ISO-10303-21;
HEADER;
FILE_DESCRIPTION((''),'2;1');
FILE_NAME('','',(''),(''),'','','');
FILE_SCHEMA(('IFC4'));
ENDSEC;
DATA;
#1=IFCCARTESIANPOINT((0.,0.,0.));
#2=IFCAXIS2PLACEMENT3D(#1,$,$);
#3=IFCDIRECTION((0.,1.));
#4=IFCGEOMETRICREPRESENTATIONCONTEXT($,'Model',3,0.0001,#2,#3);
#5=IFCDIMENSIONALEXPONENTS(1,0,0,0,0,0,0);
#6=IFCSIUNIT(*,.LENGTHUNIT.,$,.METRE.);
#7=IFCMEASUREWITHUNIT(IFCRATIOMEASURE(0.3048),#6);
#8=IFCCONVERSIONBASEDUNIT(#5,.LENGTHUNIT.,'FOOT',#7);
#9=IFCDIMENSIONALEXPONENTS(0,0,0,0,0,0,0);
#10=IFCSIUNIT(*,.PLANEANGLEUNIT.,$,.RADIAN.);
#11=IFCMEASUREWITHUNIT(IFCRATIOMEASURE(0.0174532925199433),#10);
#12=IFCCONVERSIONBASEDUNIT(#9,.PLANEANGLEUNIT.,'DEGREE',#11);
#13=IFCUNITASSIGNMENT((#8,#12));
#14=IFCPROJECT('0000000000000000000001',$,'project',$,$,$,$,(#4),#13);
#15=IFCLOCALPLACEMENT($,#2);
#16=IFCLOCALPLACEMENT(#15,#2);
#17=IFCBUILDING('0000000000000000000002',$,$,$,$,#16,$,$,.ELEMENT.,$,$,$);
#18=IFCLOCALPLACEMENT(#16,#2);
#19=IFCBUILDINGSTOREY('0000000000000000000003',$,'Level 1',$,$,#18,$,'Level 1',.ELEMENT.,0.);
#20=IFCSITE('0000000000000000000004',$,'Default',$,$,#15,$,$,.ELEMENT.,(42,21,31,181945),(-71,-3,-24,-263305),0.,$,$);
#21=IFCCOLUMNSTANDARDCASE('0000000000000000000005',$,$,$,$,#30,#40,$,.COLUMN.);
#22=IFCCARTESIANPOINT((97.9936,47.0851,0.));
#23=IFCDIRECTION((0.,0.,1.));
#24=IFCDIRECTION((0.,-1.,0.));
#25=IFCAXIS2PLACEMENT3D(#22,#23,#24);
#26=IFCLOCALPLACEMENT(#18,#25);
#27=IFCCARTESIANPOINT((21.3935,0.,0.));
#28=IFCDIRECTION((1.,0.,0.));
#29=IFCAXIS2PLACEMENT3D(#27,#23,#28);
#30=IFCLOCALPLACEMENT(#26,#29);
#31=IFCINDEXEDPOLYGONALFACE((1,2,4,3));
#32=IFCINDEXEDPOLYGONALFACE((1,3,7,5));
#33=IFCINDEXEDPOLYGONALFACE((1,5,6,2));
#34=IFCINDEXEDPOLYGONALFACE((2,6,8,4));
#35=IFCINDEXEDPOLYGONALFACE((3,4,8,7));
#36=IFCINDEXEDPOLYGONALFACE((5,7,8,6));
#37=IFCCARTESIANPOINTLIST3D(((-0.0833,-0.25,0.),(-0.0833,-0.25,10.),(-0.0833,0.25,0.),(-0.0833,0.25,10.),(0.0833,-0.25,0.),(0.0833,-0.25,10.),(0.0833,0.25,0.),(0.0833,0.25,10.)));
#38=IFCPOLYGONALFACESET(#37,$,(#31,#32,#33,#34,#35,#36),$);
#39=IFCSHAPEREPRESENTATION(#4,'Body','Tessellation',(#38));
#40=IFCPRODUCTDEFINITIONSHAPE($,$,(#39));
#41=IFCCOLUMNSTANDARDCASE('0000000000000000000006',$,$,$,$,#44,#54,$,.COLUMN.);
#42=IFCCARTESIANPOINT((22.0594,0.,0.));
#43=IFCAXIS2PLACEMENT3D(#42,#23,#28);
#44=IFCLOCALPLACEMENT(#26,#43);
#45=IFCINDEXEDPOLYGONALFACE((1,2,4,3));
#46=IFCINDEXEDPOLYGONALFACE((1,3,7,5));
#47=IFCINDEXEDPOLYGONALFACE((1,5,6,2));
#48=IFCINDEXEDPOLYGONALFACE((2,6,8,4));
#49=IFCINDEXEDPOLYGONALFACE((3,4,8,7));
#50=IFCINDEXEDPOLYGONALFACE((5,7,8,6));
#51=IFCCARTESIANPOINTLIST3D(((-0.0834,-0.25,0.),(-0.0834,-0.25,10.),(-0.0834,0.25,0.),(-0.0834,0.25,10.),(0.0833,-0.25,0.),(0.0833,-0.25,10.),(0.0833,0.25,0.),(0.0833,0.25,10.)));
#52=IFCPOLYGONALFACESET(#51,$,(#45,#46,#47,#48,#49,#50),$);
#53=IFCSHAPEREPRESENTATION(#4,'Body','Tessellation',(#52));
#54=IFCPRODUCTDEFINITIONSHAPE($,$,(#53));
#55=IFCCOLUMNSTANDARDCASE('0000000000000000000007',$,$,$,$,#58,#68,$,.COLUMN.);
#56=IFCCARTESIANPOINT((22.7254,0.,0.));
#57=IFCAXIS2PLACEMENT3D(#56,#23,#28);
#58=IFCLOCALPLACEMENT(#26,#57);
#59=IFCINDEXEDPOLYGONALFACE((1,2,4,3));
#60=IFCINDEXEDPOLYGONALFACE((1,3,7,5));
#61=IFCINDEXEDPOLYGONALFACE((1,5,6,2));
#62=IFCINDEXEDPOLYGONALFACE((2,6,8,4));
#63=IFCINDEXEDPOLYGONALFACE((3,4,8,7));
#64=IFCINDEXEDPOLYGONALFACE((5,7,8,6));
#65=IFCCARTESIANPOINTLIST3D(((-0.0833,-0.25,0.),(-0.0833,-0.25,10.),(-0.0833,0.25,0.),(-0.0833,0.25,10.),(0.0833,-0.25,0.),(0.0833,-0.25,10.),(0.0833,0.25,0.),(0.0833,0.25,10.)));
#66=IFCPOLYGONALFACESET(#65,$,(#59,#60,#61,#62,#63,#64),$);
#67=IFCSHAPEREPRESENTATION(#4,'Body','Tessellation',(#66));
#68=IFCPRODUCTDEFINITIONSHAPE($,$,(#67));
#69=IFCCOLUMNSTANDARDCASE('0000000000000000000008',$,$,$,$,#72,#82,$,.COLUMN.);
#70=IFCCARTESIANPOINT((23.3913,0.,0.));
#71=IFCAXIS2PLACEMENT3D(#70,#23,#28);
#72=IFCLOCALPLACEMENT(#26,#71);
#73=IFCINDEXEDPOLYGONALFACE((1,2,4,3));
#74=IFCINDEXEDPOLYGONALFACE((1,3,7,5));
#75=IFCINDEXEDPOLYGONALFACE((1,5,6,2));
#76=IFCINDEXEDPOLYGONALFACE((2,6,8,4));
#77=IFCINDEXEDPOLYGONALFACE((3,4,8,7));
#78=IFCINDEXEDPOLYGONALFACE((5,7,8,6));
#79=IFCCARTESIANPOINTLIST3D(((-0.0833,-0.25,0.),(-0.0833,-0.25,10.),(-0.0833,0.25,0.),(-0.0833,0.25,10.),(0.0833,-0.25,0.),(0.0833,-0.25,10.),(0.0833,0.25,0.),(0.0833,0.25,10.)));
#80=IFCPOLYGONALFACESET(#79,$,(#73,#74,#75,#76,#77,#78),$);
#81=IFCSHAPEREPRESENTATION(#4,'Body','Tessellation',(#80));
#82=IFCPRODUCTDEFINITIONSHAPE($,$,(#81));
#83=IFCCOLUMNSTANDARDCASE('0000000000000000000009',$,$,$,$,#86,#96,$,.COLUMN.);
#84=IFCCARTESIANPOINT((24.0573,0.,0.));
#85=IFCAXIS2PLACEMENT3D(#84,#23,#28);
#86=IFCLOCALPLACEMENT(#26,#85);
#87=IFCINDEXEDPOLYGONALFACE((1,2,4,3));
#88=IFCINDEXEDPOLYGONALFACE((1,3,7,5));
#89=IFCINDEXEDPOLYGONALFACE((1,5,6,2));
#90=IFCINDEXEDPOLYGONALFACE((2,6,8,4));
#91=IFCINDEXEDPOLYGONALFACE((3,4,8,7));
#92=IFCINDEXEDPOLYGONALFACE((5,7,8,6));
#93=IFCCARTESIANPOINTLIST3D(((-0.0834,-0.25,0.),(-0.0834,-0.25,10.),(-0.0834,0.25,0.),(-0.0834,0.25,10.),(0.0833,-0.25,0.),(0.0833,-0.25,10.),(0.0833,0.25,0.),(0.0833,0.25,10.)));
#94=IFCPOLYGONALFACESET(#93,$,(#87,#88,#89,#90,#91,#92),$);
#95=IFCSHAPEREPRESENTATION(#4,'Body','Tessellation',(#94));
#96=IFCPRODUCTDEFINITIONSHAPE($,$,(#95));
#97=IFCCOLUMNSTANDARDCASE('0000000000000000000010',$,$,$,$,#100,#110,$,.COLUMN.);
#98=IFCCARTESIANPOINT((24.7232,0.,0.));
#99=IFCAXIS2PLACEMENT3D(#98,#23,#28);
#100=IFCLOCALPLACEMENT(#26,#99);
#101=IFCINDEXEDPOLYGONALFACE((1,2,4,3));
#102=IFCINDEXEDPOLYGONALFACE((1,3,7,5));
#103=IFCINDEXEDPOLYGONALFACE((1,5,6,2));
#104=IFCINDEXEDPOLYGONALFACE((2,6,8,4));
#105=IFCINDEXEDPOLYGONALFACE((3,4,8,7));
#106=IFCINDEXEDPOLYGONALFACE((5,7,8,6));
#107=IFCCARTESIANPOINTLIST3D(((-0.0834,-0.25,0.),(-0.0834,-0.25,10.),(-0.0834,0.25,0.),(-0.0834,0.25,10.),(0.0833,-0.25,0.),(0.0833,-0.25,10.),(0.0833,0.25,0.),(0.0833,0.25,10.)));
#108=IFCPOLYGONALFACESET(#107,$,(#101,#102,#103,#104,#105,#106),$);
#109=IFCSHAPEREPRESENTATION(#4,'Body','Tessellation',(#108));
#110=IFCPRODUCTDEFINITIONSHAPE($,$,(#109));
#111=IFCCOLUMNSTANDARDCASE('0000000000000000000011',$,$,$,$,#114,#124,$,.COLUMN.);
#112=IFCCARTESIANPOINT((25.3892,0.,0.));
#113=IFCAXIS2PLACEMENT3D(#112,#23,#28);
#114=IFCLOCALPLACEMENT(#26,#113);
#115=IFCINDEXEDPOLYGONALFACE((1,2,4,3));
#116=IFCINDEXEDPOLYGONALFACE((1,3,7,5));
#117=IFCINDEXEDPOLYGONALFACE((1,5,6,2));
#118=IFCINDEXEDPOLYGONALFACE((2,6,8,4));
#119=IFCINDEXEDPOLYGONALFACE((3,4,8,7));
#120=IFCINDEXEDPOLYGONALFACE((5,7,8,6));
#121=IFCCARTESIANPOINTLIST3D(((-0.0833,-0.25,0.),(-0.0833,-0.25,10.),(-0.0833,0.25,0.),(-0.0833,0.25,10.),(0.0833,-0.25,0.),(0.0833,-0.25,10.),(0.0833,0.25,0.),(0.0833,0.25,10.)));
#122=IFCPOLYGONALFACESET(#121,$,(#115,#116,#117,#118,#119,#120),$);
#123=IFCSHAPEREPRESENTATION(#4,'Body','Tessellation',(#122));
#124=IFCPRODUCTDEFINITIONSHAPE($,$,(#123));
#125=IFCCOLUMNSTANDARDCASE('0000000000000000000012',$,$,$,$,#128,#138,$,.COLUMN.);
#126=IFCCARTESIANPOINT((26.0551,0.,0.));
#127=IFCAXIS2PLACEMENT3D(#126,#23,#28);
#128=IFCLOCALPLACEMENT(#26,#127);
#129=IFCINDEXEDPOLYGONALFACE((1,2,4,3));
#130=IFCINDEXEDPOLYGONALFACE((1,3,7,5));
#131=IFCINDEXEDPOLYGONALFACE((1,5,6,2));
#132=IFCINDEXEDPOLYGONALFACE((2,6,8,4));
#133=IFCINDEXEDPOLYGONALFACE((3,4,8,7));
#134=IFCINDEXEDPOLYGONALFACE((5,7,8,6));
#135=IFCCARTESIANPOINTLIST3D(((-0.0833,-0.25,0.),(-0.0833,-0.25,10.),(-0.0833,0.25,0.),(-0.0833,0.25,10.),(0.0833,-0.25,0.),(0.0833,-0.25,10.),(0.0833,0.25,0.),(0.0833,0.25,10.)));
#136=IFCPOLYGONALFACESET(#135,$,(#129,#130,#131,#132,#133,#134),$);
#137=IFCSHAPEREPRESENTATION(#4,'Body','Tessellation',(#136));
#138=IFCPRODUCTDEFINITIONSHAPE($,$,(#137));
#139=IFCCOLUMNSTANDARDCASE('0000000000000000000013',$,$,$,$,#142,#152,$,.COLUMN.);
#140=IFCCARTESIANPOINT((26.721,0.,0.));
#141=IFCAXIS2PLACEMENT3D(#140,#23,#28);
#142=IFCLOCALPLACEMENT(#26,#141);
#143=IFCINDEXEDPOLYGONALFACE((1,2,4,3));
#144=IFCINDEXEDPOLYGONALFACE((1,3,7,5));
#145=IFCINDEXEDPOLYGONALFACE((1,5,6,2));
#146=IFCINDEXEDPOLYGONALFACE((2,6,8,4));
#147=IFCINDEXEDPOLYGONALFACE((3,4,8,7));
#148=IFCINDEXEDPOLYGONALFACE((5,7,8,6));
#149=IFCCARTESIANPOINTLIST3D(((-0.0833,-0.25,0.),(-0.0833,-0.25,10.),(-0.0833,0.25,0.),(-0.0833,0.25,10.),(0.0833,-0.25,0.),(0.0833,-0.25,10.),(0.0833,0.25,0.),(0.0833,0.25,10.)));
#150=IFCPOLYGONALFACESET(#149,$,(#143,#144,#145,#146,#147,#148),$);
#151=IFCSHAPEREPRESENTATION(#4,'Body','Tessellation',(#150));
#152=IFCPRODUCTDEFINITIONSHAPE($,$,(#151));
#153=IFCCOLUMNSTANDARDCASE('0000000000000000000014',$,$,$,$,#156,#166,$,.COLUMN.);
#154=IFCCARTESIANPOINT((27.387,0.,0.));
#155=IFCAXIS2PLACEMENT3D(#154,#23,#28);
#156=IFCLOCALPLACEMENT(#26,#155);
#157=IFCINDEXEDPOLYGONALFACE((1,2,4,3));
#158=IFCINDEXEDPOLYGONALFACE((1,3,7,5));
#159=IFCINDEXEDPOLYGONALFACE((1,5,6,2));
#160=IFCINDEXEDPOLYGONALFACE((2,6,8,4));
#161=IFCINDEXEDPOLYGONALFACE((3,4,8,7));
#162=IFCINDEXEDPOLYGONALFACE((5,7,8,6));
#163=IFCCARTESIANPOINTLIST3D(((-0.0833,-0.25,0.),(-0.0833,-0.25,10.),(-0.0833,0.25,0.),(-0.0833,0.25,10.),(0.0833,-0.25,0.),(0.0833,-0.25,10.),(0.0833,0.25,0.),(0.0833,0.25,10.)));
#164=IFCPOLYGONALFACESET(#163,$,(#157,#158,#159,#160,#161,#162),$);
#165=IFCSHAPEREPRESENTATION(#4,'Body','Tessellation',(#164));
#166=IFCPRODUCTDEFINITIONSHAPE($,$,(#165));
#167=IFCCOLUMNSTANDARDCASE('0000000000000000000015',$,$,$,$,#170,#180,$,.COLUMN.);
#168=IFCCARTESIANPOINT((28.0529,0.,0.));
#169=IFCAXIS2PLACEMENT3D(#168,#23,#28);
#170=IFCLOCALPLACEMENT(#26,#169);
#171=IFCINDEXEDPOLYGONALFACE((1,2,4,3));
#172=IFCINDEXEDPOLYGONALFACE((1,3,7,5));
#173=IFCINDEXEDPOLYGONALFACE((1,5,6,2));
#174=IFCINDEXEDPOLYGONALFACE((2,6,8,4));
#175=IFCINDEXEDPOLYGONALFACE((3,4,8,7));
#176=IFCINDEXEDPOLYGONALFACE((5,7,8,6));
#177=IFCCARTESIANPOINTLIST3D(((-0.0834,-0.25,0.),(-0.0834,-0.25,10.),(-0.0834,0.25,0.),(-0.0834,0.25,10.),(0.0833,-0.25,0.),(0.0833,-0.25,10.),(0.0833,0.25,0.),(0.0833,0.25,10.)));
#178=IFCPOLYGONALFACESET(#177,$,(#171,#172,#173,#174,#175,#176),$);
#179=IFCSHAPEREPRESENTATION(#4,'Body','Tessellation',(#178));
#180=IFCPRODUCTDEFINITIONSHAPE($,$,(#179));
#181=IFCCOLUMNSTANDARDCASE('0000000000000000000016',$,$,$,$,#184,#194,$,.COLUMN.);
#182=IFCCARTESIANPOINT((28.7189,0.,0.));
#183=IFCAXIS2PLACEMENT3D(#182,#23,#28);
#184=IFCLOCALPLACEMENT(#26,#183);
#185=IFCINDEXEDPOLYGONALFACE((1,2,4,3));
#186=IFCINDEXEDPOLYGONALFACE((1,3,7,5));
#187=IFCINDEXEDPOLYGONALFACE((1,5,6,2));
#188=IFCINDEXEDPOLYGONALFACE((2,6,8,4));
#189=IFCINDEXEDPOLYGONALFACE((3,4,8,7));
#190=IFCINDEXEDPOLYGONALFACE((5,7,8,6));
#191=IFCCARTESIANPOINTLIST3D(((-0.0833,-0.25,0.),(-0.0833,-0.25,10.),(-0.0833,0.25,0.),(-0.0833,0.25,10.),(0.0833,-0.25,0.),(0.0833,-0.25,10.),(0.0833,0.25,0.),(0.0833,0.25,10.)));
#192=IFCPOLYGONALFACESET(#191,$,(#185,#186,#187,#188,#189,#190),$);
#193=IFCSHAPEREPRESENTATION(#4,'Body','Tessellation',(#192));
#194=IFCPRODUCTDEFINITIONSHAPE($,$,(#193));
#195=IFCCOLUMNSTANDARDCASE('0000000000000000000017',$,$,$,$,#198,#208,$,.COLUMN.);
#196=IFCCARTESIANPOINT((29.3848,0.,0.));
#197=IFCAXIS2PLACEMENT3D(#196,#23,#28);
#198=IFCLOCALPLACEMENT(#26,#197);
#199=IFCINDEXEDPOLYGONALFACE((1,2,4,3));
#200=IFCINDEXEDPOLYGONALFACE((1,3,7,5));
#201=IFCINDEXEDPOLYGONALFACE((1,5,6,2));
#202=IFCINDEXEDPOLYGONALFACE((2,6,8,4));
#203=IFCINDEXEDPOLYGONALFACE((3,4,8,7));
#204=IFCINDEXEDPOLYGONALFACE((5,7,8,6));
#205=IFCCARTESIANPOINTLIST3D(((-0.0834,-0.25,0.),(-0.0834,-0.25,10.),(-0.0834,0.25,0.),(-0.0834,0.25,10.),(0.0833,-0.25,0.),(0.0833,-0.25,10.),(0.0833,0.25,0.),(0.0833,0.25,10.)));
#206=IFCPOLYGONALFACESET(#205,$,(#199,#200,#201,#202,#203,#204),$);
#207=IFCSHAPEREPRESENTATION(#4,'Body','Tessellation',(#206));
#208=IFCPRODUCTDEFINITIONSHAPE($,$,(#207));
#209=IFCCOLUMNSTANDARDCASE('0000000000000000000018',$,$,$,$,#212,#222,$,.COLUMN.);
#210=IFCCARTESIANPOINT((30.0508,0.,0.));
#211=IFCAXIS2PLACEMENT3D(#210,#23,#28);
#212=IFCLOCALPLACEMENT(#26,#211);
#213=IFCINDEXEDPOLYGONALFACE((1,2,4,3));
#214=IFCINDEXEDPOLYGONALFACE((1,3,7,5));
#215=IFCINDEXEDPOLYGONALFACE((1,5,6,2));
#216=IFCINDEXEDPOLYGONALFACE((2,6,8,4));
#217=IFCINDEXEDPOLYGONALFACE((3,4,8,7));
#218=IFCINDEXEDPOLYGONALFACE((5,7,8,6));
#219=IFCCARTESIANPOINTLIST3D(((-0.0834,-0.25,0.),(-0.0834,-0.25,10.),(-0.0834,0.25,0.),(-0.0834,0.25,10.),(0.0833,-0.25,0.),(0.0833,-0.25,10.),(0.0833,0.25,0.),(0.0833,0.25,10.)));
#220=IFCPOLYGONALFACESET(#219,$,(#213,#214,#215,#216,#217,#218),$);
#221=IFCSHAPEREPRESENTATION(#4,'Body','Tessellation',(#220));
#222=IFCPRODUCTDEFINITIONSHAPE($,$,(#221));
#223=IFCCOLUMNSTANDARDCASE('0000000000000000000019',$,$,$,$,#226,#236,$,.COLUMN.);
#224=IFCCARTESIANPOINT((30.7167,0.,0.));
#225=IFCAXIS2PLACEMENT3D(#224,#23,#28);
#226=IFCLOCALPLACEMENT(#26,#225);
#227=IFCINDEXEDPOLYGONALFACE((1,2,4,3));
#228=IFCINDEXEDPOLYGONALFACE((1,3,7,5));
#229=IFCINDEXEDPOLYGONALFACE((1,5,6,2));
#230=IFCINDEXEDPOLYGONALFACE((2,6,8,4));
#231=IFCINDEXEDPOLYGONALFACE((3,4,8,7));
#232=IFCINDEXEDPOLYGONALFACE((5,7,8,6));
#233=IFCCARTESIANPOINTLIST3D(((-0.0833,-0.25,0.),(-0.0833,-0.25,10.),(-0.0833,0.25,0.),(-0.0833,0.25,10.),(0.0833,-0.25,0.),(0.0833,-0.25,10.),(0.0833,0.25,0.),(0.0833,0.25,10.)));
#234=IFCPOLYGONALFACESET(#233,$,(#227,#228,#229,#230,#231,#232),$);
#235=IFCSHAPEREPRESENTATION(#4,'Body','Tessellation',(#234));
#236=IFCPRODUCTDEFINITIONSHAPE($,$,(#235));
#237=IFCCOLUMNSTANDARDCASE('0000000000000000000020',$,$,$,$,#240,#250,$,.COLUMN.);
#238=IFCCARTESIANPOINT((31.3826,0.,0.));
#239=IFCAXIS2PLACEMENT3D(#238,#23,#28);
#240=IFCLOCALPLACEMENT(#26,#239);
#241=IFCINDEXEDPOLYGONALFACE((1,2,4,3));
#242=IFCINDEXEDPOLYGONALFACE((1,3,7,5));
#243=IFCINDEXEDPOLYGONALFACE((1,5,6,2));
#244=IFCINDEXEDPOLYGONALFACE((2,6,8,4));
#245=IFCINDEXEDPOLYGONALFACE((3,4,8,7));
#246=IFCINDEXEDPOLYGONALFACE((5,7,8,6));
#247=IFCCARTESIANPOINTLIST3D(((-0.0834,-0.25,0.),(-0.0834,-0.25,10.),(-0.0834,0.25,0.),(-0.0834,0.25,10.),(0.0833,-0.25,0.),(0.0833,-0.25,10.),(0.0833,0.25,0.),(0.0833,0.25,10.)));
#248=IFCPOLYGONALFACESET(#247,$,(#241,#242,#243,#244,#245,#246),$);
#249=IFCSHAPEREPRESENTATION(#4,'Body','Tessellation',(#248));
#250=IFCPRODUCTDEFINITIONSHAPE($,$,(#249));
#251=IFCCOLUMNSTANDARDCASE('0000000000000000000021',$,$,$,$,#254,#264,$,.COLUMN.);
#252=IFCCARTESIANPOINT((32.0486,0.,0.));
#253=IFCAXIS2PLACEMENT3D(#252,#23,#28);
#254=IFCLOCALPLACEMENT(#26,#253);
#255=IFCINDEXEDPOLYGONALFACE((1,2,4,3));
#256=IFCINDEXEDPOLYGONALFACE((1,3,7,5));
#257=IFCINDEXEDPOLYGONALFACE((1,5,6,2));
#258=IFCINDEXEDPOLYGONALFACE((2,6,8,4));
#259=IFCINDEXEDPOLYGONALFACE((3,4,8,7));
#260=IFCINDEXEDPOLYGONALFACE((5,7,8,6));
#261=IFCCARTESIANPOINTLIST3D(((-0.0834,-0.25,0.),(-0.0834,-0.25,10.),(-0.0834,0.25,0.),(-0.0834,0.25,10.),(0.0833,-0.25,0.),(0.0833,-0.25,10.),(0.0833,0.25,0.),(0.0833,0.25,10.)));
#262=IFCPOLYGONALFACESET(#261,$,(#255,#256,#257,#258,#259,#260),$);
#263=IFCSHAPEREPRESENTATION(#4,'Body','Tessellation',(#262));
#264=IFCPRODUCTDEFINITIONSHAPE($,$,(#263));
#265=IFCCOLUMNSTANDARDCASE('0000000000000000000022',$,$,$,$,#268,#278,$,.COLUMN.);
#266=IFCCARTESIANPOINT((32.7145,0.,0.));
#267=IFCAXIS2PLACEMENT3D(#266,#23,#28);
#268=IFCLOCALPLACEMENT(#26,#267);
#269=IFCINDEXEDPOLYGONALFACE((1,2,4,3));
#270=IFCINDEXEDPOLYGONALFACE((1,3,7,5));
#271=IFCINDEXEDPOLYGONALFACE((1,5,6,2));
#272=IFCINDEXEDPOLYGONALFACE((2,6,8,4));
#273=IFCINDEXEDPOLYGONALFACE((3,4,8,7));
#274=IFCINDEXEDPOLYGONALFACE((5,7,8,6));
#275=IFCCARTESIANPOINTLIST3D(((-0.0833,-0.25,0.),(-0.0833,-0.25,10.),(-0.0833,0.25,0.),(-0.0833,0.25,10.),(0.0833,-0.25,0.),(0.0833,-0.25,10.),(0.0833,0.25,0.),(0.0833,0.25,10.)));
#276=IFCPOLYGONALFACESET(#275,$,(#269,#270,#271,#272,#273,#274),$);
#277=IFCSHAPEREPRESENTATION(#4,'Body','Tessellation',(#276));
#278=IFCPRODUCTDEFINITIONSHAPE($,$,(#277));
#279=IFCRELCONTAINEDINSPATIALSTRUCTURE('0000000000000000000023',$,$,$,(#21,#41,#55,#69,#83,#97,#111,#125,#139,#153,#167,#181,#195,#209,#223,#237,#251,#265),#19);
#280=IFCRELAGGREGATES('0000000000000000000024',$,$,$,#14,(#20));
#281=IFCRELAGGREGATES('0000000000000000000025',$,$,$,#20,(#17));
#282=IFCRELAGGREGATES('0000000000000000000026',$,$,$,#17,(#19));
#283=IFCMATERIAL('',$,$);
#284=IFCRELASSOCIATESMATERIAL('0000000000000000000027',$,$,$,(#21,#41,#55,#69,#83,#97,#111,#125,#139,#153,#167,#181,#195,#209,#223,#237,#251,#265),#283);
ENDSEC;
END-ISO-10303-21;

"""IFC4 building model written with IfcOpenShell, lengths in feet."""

from ifc_helpers import new_model, entity, si_unit, converted_unit, direction, frame, origin, place, context, project, spatial, rectangle, extrude, material, element, save


model = new_model("IFC4")

# Units and contexts
model_context = context("Model", 3, precision=0.0001, world=origin(), true_north=direction((0.0, 1.0)))
ifc_project = project(units=[converted_unit("LENGTHUNIT", "FOOT", entity("IfcRatioMeasure", 0.3048), si_unit("LENGTHUNIT", "METRE"), dimensions=[1, 0, 0, 0, 0, 0, 0]), converted_unit("PLANEANGLEUNIT", "DEGREE", entity("IfcRatioMeasure", 0.0174532925199433), si_unit("PLANEANGLEUNIT", "RADIAN"), dimensions=[0, 0, 0, 0, 0, 0, 0])], contexts=[model_context])

# Site, building, storey
site_placement = place(None, origin())
site = spatial("IfcSite", under=ifc_project, at=site_placement, Name="Default", CompositionType="ELEMENT", RefLatitude=(42, 21, 31, 181945), RefLongitude=(-71, -3, -24, -263305), RefElevation=0.0)
building_placement = place(site_placement, origin())
building = spatial("IfcBuilding", under=site, at=building_placement, CompositionType="ELEMENT")
storey_placement = place(building_placement, origin())
storey = spatial("IfcBuildingStorey", under=building, at=storey_placement, Name="Level 1", LongName="Level 1", CompositionType="ELEMENT", Elevation=0.0)

# Columns
ifc_material = material(Name="")
placement = place(storey_placement, frame((97.9936, 47.0851, 0.0), z_axis=(0.0, 0.0, 1.0), x_axis=(0.0, -1.0, 0.0)))
for number, where, z_axis, x_axis in (
    (1, (21.3935, 0.0, 0.0), (0.0, 0.0, 1.0), (1.0, 0.0, 0.0)),
    (2, (22.0594, 0.0, 0.0), (0.0, 0.0, 1.0), (1.0, 0.0, 0.0)),
    (3, (22.7254, 0.0, 0.0), (0.0, 0.0, 1.0), (1.0, 0.0, 0.0)),
    (4, (23.3913, 0.0, 0.0), (0.0, 0.0, 1.0), (1.0, 0.0, 0.0)),
    (5, (24.0573, 0.0, 0.0), (0.0, 0.0, 1.0), (1.0, 0.0, 0.0)),
    (6, (24.7232, 0.0, 0.0), (0.0, 0.0, 1.0), (1.0, 0.0, 0.0)),
    (7, (25.3892, 0.0, 0.0), (0.0, 0.0, 1.0), (1.0, 0.0, 0.0)),
    (8, (26.0551, 0.0, 0.0), (0.0, 0.0, 1.0), (1.0, 0.0, 0.0)),
    (9, (26.721, 0.0, 0.0), (0.0, 0.0, 1.0), (1.0, 0.0, 0.0)),
    (10, (27.387, 0.0, 0.0), (0.0, 0.0, 1.0), (1.0, 0.0, 0.0)),
    (11, (28.0529, 0.0, 0.0), (0.0, 0.0, 1.0), (1.0, 0.0, 0.0)),
    (12, (28.7189, 0.0, 0.0), (0.0, 0.0, 1.0), (1.0, 0.0, 0.0)),
    (13, (29.3848, 0.0, 0.0), (0.0, 0.0, 1.0), (1.0, 0.0, 0.0)),
    (14, (30.0508, 0.0, 0.0), (0.0, 0.0, 1.0), (1.0, 0.0, 0.0)),
    (15, (30.7167, 0.0, 0.0), (0.0, 0.0, 1.0), (1.0, 0.0, 0.0)),
    (16, (31.3826, 0.0, 0.0), (0.0, 0.0, 1.0), (1.0, 0.0, 0.0)),
    (17, (32.0486, 0.0, 0.0), (0.0, 0.0, 1.0), (1.0, 0.0, 0.0)),
    (18, (32.7145, 0.0, 0.0), (0.0, 0.0, 1.0), (1.0, 0.0, 0.0)),
):
    element("IfcColumnStandardCase", number, at=place(placement, frame(where, z_axis=z_axis, x_axis=x_axis)), inside=storey, material=ifc_material, PredefinedType="COLUMN", context=model_context, shape_type="SweptSolid", body=[
        extrude(rectangle(XDim=0.1667, YDim=0.5), origin(), (0.0, 0.0, 1.0), 10.0),
    ])

save(model, "model.ifc")
